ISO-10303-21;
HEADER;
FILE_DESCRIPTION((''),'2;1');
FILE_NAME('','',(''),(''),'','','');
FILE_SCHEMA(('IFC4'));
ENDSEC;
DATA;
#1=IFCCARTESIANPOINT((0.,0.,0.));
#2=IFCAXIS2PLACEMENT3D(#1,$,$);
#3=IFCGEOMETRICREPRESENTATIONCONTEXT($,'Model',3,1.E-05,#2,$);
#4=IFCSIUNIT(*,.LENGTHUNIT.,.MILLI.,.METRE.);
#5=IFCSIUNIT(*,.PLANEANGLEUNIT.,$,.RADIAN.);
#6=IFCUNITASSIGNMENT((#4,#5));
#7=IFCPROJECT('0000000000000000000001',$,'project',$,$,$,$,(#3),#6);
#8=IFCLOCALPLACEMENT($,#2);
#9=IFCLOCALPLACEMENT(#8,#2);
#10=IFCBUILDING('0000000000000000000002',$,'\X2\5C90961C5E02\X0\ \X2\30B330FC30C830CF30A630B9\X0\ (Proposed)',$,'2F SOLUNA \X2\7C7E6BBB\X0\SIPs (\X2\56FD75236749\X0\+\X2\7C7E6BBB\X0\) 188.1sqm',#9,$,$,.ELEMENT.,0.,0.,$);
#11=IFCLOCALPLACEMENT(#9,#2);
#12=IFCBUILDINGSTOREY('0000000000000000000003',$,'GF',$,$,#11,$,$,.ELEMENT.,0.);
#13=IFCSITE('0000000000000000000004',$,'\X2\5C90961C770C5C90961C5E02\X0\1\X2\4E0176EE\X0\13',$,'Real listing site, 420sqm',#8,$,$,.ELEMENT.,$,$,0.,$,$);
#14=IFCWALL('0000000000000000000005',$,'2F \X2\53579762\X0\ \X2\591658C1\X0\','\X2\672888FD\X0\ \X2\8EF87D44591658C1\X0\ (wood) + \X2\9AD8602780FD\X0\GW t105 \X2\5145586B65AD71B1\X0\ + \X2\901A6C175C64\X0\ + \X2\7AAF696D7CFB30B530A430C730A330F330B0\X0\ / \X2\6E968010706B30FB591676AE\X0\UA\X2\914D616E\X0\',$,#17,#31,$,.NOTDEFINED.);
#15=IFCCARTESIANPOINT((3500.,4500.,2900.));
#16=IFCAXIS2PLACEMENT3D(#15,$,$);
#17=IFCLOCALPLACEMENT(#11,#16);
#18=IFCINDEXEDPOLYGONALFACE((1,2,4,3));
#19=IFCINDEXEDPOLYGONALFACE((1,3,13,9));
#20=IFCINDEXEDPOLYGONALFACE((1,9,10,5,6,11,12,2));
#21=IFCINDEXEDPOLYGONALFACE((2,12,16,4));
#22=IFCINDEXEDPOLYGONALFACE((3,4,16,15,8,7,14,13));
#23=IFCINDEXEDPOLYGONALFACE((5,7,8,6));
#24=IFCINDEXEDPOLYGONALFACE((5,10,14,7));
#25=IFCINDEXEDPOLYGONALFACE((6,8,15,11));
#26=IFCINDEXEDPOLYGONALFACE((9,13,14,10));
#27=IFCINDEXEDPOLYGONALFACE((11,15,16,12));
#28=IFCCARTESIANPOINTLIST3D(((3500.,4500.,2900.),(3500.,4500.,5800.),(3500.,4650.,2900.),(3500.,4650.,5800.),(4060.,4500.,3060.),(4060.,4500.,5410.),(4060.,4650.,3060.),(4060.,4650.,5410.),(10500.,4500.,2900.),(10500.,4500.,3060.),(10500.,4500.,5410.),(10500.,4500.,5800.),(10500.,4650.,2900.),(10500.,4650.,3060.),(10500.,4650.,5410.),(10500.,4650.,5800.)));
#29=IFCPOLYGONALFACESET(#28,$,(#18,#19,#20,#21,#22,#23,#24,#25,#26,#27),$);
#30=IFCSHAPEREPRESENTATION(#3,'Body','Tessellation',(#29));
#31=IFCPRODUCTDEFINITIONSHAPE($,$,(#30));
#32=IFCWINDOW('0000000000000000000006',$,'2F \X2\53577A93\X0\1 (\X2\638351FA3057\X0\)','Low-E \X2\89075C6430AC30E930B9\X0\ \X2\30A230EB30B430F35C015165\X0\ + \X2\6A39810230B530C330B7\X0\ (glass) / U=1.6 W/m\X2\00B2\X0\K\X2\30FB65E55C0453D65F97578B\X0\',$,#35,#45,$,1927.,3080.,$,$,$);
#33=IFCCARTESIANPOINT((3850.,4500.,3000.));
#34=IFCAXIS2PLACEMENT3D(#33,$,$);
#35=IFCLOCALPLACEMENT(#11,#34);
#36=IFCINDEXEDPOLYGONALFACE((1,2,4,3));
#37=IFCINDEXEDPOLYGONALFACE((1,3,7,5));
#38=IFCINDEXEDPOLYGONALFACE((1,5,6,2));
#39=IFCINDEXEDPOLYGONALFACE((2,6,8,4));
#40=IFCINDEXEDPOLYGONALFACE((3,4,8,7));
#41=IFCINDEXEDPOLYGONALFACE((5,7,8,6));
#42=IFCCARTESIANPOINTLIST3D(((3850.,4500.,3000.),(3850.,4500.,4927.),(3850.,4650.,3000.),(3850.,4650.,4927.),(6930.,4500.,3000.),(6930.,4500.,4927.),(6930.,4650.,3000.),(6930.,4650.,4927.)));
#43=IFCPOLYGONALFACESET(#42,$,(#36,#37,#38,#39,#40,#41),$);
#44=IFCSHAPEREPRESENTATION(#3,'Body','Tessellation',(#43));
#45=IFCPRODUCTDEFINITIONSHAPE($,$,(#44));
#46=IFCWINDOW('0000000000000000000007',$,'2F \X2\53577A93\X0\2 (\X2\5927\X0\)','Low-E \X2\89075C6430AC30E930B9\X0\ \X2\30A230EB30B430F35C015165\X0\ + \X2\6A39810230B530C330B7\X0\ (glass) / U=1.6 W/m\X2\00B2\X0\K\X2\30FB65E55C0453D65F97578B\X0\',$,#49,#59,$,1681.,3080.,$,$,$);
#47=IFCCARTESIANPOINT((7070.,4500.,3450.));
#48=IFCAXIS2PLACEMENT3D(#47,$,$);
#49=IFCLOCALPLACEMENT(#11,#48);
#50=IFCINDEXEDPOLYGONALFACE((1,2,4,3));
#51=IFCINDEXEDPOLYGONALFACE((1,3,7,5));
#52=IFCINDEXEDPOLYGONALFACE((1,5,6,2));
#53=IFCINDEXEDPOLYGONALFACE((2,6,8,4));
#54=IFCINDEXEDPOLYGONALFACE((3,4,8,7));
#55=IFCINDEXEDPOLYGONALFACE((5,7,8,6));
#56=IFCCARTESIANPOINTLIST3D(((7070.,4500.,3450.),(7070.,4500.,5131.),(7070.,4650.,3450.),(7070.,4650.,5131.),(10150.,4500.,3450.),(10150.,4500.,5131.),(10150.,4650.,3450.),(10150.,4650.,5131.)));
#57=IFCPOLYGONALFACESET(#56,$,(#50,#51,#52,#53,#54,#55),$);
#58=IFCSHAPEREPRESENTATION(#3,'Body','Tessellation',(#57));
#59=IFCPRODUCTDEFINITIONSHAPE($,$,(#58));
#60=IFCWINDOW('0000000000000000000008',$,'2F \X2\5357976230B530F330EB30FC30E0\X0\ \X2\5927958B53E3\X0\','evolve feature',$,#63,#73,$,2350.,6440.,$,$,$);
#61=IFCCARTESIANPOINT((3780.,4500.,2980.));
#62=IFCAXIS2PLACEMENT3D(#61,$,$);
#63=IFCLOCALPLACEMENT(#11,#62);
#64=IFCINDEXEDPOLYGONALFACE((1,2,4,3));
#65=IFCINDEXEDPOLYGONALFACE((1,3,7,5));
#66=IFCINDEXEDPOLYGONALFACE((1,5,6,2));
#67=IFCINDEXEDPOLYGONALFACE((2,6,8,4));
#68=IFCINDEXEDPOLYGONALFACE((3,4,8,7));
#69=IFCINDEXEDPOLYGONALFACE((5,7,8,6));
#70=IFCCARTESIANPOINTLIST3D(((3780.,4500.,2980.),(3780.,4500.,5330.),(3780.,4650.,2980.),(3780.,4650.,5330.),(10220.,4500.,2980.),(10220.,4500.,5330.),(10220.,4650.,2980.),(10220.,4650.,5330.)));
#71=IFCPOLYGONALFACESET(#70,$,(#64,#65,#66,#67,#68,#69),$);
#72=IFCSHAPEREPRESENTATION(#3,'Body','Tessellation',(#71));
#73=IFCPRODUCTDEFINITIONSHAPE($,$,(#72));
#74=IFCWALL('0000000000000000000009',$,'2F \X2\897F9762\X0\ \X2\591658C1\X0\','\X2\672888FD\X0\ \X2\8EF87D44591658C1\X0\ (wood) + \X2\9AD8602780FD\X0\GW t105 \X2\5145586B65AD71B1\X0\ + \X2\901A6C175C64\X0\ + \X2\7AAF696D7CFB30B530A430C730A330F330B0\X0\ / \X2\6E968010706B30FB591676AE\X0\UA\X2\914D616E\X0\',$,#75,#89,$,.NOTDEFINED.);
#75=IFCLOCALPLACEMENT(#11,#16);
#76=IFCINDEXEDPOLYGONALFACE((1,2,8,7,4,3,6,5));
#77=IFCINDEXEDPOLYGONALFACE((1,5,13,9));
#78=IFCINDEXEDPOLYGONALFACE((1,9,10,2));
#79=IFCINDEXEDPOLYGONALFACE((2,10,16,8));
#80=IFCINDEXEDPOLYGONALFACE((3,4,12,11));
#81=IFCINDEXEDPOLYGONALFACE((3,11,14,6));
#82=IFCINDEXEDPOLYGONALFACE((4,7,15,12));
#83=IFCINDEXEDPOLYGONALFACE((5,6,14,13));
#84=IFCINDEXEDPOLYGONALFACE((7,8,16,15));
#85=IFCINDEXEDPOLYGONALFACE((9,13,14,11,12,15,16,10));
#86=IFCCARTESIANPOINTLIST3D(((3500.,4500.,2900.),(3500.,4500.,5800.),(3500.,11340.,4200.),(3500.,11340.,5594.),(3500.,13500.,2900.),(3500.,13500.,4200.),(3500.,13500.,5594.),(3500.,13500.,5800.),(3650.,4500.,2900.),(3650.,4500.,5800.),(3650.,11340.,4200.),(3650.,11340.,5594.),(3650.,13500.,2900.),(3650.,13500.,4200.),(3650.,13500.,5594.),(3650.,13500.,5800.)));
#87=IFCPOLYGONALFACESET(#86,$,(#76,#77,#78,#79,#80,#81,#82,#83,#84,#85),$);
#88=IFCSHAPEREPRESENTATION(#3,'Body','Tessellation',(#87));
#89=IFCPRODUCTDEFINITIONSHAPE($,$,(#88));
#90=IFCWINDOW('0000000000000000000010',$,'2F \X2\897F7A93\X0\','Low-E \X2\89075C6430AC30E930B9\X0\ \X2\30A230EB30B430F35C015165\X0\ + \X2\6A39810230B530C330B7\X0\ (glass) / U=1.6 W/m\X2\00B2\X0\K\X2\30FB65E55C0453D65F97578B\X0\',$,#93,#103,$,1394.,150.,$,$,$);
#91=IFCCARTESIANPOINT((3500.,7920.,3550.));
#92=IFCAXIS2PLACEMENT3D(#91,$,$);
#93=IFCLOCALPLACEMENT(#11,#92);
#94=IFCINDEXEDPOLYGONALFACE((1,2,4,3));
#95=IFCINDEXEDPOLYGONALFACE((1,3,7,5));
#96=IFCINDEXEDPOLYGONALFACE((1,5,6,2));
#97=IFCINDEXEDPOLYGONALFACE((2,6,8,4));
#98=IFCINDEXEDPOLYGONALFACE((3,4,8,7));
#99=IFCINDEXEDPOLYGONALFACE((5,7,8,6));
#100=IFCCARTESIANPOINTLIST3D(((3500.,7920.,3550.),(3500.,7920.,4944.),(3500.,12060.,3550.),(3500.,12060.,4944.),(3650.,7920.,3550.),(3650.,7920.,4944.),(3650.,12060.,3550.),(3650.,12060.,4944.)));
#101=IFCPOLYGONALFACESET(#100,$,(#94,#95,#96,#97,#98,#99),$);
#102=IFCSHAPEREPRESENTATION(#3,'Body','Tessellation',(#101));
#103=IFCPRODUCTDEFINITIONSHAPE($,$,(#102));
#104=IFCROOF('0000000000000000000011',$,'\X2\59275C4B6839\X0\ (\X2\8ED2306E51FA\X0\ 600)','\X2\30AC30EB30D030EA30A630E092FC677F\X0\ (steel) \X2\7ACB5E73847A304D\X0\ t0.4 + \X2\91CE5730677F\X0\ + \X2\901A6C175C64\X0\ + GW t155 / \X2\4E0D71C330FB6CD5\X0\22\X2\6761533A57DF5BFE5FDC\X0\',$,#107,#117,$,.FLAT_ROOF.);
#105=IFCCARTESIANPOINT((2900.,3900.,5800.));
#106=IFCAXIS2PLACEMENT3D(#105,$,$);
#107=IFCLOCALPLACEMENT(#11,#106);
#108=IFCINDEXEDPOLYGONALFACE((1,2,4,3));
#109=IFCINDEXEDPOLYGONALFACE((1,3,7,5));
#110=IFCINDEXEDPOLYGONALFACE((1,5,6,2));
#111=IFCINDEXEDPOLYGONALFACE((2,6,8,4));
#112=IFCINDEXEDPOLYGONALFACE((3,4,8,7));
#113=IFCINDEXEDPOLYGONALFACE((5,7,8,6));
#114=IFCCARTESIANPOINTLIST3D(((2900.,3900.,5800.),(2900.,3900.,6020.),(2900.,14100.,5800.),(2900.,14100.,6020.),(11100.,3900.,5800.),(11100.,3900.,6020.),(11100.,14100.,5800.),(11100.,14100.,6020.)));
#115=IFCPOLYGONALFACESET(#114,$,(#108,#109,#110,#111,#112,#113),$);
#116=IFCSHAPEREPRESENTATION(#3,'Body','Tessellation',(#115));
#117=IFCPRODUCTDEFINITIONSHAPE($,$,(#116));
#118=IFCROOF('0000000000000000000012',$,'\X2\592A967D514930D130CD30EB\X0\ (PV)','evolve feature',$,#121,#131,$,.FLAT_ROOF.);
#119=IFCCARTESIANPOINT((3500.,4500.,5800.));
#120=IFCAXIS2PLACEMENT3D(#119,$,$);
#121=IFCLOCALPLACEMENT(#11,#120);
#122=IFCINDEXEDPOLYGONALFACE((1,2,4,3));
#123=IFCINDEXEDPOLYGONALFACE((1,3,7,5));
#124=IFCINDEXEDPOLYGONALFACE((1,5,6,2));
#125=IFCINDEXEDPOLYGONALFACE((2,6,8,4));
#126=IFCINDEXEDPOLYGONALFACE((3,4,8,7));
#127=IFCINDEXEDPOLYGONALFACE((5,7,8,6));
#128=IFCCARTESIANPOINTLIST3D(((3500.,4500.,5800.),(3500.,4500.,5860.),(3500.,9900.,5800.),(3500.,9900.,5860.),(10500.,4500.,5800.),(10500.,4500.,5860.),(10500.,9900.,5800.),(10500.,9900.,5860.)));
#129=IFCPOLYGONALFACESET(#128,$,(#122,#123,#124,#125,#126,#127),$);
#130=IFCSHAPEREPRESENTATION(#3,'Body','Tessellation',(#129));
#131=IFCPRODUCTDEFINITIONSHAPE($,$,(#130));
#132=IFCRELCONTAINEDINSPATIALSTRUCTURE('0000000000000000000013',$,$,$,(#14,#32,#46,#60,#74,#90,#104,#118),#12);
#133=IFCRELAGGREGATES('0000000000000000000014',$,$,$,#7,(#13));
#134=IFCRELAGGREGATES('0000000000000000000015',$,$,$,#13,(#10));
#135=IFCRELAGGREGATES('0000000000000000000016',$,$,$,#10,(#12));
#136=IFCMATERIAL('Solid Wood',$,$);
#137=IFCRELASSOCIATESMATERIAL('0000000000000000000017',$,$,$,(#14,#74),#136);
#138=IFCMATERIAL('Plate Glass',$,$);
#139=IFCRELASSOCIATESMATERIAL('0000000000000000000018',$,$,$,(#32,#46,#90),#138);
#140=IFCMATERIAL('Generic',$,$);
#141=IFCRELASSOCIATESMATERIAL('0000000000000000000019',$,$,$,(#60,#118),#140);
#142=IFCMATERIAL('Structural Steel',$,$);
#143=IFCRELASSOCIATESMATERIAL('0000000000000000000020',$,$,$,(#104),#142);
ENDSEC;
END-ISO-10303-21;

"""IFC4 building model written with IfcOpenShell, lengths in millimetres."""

from ifc_helpers import new_model, si_unit, frame, frame_2d, origin, place, context, project, spatial, rectangle, extrude, material, element, fill, save


model = new_model("IFC4")

# Units and contexts
model_context = context("Model", 3, precision=1e-05, world=origin())
ifc_project = project(units=[si_unit("LENGTHUNIT", "METRE", prefix="MILLI"), si_unit("PLANEANGLEUNIT", "RADIAN")], contexts=[model_context])

# Site, building, storey
site_placement = place(None, origin())
site = spatial("IfcSite", under=ifc_project, at=site_placement, Name="岐阜県岐阜市1丁目13", ObjectType="Real listing site, 420sqm", CompositionType="ELEMENT", RefElevation=0.0)
building_placement = place(site_placement, origin())
building = spatial("IfcBuilding", under=site, at=building_placement, Name="岐阜市 コートハウス (Proposed)", ObjectType="2F SOLUNA 籾殻SIPs (国産杉+籾殻) 188.1sqm", CompositionType="ELEMENT", ElevationOfRefHeight=0.0, ElevationOfTerrain=0.0)
storey_placement = place(building_placement, origin())
storey = spatial("IfcBuildingStorey", under=building, at=storey_placement, Name="GF", CompositionType="ELEMENT", Elevation=0.0)

# Shared definitions
ifc_material_1 = material(Name="Solid Wood")
ifc_material_2 = material(Name="Generic")

# Shared definitions
ifc_material_3 = material(Name="Plate Glass")

# Wall, openings, windows
wall_1_placement = place(storey_placement, frame((3500.0, 4500.0, 2900.0)))
wall_1 = element("IfcWall", 1, at=wall_1_placement, inside=storey, material=ifc_material_1, Name="2F 南面 外壁", Description="木製 軸組外壁 (wood) + 高性能GW t105 充填断熱 + 通気層 + 窯業系サイディング / 準耐火・外皮UA配慮", PredefinedType="NOTDEFINED", context=model_context, shape_type="SweptSolid", body=[
    extrude(rectangle(XDim=7000.0, YDim=150.0, at=frame_2d((3500.0, 75.0))), frame((3500.0, 4500.0, 2900.0)), (0.0, 0.0, 1.0), 2900.0),
])
opening_1_placement = place(storey_placement, frame((3850.0, 4500.0, 3000.0)))
opening_1 = element("IfcOpeningElement", 2, at=opening_1_placement, cuts=wall_1, PredefinedType="NOTDEFINED", context=model_context, shape_type="SweptSolid", body=[
    extrude(rectangle(XDim=3080.0, YDim=150.0, at=frame_2d((1540.0, 75.0))), frame((3850.0, 4500.0, 3000.0)), (0.0, 0.0, 1.0), 1927.0),
])
opening_2_placement = place(storey_placement, frame((7070.0, 4500.0, 3450.0)))
opening_2 = element("IfcOpeningElement", 3, at=opening_2_placement, cuts=wall_1, PredefinedType="NOTDEFINED", context=model_context, shape_type="SweptSolid", body=[
    extrude(rectangle(XDim=3080.0, YDim=150.0, at=frame_2d((1540.0, 75.0))), frame((7070.0, 4500.0, 3450.0)), (0.0, 0.0, 1.0), 1681.0),
])
opening_3_placement = place(storey_placement, frame((3780.0, 4500.0, 2980.0)))
opening_3 = element("IfcOpeningElement", 4, at=opening_3_placement, cuts=wall_1, PredefinedType="NOTDEFINED", context=model_context, shape_type="SweptSolid", body=[
    extrude(rectangle(XDim=6440.0, YDim=150.0, at=frame_2d((3220.0, 75.0))), frame((3780.0, 4500.0, 2980.0)), (0.0, 0.0, 1.0), 2350.0),
])
window_1_placement = place(storey_placement, frame((3850.0, 4500.0, 3000.0)))
window_1 = element("IfcWindow", 5, at=window_1_placement, inside=storey, material=ifc_material_3, Name="2F 南窓1 (掃出し)", Description="Low-E 複層ガラス アルゴン封入 + 樹脂サッシ (glass) / U=1.6 W/m²K・日射取得型", OverallHeight=1927.0, OverallWidth=3080.0, context=model_context, shape_type="SweptSolid", body=[
    extrude(rectangle(XDim=3080.0, YDim=150.0, at=frame_2d((1540.0, 75.0))), frame((3850.0, 4500.0, 3000.0)), (0.0, 0.0, 1.0), 1927.0),
])
fill(opening_1, window_1)
window_2_placement = place(storey_placement, frame((7070.0, 4500.0, 3450.0)))
window_2 = element("IfcWindow", 6, at=window_2_placement, inside=storey, material=ifc_material_3, Name="2F 南窓2 (大)", Description="Low-E 複層ガラス アルゴン封入 + 樹脂サッシ (glass) / U=1.6 W/m²K・日射取得型", OverallHeight=1681.0, OverallWidth=3080.0, context=model_context, shape_type="SweptSolid", body=[
    extrude(rectangle(XDim=3080.0, YDim=150.0, at=frame_2d((1540.0, 75.0))), frame((7070.0, 4500.0, 3450.0)), (0.0, 0.0, 1.0), 1681.0),
])
fill(opening_2, window_2)
window_3_placement = place(storey_placement, frame((3780.0, 4500.0, 2980.0)))
window_3 = element("IfcWindow", 7, at=window_3_placement, inside=storey, material=ifc_material_2, Name="2F 南面サンルーム 大開口", Description="evolve feature", OverallHeight=2350.0, OverallWidth=6440.0, context=model_context, shape_type="SweptSolid", body=[
    extrude(rectangle(XDim=6440.0, YDim=150.0, at=frame_2d((3220.0, 75.0))), frame((3780.0, 4500.0, 2980.0)), (0.0, 0.0, 1.0), 2350.0),
])
fill(opening_3, window_3)

# Wall, opening, window
wall_2_placement = place(storey_placement, frame((3500.0, 4500.0, 2900.0)))
wall_2 = element("IfcWall", 8, at=wall_2_placement, inside=storey, material=ifc_material_1, Name="2F 西面 外壁", Description="木製 軸組外壁 (wood) + 高性能GW t105 充填断熱 + 通気層 + 窯業系サイディング / 準耐火・外皮UA配慮", PredefinedType="NOTDEFINED", context=model_context, shape_type="SweptSolid", body=[
    extrude(rectangle(XDim=150.0, YDim=9000.0, at=frame_2d((75.0, 4500.0))), frame((3500.0, 4500.0, 2900.0)), (0.0, 0.0, 1.0), 2900.0),
])
opening_4_placement = place(storey_placement, frame((3500.0, 7920.0, 3550.0)))
opening_4 = element("IfcOpeningElement", 9, at=opening_4_placement, cuts=wall_2, PredefinedType="NOTDEFINED", context=model_context, shape_type="SweptSolid", body=[
    extrude(rectangle(XDim=150.0, YDim=4140.0, at=frame_2d((75.0, 2070.0))), frame((3500.0, 7920.0, 3550.0)), (0.0, 0.0, 1.0), 1394.0),
])
window_4_placement = place(storey_placement, frame((3500.0, 7920.0, 3550.0)))
window_4 = element("IfcWindow", 10, at=window_4_placement, inside=storey, material=ifc_material_3, Name="2F 西窓", Description="Low-E 複層ガラス アルゴン封入 + 樹脂サッシ (glass) / U=1.6 W/m²K・日射取得型", OverallHeight=1394.0, OverallWidth=150.0, context=model_context, shape_type="SweptSolid", body=[
    extrude(rectangle(XDim=150.0, YDim=4140.0, at=frame_2d((75.0, 2070.0))), frame((3500.0, 7920.0, 3550.0)), (0.0, 0.0, 1.0), 1394.0),
])
fill(opening_4, window_4)

# Roofs
ifc_material_4 = material(Name="Structural Steel")
roof_1_placement = place(storey_placement, frame((2900.0, 3900.0, 5800.0)))
element("IfcRoof", 11, at=roof_1_placement, inside=storey, material=ifc_material_4, Name="大屋根 (軒の出 600)", Description="ガルバリウム鋼板 (steel) 立平葺き t0.4 + 野地板 + 通気層 + GW t155 / 不燃・法22条区域対応", PredefinedType="FLAT_ROOF", context=model_context, shape_type="SweptSolid", body=[
    extrude(rectangle(XDim=8200.0, YDim=10200.0, at=frame_2d((4100.0, 5100.0))), frame((2900.0, 3900.0, 5800.0)), (0.0, 0.0, 1.0), 220.0),
])
roof_2_placement = place(storey_placement, frame((3500.0, 4500.0, 5800.0)))
element("IfcRoof", 12, at=roof_2_placement, inside=storey, material=ifc_material_2, Name="太陽光パネル (PV)", Description="evolve feature", PredefinedType="FLAT_ROOF", context=model_context, shape_type="SweptSolid", body=[
    extrude(rectangle(XDim=7000.0, YDim=5400.0, at=frame_2d((3500.0, 2700.0))), frame((3500.0, 4500.0, 5800.0)), (0.0, 0.0, 1.0), 60.0),
])

save(model, "model.ifc")
